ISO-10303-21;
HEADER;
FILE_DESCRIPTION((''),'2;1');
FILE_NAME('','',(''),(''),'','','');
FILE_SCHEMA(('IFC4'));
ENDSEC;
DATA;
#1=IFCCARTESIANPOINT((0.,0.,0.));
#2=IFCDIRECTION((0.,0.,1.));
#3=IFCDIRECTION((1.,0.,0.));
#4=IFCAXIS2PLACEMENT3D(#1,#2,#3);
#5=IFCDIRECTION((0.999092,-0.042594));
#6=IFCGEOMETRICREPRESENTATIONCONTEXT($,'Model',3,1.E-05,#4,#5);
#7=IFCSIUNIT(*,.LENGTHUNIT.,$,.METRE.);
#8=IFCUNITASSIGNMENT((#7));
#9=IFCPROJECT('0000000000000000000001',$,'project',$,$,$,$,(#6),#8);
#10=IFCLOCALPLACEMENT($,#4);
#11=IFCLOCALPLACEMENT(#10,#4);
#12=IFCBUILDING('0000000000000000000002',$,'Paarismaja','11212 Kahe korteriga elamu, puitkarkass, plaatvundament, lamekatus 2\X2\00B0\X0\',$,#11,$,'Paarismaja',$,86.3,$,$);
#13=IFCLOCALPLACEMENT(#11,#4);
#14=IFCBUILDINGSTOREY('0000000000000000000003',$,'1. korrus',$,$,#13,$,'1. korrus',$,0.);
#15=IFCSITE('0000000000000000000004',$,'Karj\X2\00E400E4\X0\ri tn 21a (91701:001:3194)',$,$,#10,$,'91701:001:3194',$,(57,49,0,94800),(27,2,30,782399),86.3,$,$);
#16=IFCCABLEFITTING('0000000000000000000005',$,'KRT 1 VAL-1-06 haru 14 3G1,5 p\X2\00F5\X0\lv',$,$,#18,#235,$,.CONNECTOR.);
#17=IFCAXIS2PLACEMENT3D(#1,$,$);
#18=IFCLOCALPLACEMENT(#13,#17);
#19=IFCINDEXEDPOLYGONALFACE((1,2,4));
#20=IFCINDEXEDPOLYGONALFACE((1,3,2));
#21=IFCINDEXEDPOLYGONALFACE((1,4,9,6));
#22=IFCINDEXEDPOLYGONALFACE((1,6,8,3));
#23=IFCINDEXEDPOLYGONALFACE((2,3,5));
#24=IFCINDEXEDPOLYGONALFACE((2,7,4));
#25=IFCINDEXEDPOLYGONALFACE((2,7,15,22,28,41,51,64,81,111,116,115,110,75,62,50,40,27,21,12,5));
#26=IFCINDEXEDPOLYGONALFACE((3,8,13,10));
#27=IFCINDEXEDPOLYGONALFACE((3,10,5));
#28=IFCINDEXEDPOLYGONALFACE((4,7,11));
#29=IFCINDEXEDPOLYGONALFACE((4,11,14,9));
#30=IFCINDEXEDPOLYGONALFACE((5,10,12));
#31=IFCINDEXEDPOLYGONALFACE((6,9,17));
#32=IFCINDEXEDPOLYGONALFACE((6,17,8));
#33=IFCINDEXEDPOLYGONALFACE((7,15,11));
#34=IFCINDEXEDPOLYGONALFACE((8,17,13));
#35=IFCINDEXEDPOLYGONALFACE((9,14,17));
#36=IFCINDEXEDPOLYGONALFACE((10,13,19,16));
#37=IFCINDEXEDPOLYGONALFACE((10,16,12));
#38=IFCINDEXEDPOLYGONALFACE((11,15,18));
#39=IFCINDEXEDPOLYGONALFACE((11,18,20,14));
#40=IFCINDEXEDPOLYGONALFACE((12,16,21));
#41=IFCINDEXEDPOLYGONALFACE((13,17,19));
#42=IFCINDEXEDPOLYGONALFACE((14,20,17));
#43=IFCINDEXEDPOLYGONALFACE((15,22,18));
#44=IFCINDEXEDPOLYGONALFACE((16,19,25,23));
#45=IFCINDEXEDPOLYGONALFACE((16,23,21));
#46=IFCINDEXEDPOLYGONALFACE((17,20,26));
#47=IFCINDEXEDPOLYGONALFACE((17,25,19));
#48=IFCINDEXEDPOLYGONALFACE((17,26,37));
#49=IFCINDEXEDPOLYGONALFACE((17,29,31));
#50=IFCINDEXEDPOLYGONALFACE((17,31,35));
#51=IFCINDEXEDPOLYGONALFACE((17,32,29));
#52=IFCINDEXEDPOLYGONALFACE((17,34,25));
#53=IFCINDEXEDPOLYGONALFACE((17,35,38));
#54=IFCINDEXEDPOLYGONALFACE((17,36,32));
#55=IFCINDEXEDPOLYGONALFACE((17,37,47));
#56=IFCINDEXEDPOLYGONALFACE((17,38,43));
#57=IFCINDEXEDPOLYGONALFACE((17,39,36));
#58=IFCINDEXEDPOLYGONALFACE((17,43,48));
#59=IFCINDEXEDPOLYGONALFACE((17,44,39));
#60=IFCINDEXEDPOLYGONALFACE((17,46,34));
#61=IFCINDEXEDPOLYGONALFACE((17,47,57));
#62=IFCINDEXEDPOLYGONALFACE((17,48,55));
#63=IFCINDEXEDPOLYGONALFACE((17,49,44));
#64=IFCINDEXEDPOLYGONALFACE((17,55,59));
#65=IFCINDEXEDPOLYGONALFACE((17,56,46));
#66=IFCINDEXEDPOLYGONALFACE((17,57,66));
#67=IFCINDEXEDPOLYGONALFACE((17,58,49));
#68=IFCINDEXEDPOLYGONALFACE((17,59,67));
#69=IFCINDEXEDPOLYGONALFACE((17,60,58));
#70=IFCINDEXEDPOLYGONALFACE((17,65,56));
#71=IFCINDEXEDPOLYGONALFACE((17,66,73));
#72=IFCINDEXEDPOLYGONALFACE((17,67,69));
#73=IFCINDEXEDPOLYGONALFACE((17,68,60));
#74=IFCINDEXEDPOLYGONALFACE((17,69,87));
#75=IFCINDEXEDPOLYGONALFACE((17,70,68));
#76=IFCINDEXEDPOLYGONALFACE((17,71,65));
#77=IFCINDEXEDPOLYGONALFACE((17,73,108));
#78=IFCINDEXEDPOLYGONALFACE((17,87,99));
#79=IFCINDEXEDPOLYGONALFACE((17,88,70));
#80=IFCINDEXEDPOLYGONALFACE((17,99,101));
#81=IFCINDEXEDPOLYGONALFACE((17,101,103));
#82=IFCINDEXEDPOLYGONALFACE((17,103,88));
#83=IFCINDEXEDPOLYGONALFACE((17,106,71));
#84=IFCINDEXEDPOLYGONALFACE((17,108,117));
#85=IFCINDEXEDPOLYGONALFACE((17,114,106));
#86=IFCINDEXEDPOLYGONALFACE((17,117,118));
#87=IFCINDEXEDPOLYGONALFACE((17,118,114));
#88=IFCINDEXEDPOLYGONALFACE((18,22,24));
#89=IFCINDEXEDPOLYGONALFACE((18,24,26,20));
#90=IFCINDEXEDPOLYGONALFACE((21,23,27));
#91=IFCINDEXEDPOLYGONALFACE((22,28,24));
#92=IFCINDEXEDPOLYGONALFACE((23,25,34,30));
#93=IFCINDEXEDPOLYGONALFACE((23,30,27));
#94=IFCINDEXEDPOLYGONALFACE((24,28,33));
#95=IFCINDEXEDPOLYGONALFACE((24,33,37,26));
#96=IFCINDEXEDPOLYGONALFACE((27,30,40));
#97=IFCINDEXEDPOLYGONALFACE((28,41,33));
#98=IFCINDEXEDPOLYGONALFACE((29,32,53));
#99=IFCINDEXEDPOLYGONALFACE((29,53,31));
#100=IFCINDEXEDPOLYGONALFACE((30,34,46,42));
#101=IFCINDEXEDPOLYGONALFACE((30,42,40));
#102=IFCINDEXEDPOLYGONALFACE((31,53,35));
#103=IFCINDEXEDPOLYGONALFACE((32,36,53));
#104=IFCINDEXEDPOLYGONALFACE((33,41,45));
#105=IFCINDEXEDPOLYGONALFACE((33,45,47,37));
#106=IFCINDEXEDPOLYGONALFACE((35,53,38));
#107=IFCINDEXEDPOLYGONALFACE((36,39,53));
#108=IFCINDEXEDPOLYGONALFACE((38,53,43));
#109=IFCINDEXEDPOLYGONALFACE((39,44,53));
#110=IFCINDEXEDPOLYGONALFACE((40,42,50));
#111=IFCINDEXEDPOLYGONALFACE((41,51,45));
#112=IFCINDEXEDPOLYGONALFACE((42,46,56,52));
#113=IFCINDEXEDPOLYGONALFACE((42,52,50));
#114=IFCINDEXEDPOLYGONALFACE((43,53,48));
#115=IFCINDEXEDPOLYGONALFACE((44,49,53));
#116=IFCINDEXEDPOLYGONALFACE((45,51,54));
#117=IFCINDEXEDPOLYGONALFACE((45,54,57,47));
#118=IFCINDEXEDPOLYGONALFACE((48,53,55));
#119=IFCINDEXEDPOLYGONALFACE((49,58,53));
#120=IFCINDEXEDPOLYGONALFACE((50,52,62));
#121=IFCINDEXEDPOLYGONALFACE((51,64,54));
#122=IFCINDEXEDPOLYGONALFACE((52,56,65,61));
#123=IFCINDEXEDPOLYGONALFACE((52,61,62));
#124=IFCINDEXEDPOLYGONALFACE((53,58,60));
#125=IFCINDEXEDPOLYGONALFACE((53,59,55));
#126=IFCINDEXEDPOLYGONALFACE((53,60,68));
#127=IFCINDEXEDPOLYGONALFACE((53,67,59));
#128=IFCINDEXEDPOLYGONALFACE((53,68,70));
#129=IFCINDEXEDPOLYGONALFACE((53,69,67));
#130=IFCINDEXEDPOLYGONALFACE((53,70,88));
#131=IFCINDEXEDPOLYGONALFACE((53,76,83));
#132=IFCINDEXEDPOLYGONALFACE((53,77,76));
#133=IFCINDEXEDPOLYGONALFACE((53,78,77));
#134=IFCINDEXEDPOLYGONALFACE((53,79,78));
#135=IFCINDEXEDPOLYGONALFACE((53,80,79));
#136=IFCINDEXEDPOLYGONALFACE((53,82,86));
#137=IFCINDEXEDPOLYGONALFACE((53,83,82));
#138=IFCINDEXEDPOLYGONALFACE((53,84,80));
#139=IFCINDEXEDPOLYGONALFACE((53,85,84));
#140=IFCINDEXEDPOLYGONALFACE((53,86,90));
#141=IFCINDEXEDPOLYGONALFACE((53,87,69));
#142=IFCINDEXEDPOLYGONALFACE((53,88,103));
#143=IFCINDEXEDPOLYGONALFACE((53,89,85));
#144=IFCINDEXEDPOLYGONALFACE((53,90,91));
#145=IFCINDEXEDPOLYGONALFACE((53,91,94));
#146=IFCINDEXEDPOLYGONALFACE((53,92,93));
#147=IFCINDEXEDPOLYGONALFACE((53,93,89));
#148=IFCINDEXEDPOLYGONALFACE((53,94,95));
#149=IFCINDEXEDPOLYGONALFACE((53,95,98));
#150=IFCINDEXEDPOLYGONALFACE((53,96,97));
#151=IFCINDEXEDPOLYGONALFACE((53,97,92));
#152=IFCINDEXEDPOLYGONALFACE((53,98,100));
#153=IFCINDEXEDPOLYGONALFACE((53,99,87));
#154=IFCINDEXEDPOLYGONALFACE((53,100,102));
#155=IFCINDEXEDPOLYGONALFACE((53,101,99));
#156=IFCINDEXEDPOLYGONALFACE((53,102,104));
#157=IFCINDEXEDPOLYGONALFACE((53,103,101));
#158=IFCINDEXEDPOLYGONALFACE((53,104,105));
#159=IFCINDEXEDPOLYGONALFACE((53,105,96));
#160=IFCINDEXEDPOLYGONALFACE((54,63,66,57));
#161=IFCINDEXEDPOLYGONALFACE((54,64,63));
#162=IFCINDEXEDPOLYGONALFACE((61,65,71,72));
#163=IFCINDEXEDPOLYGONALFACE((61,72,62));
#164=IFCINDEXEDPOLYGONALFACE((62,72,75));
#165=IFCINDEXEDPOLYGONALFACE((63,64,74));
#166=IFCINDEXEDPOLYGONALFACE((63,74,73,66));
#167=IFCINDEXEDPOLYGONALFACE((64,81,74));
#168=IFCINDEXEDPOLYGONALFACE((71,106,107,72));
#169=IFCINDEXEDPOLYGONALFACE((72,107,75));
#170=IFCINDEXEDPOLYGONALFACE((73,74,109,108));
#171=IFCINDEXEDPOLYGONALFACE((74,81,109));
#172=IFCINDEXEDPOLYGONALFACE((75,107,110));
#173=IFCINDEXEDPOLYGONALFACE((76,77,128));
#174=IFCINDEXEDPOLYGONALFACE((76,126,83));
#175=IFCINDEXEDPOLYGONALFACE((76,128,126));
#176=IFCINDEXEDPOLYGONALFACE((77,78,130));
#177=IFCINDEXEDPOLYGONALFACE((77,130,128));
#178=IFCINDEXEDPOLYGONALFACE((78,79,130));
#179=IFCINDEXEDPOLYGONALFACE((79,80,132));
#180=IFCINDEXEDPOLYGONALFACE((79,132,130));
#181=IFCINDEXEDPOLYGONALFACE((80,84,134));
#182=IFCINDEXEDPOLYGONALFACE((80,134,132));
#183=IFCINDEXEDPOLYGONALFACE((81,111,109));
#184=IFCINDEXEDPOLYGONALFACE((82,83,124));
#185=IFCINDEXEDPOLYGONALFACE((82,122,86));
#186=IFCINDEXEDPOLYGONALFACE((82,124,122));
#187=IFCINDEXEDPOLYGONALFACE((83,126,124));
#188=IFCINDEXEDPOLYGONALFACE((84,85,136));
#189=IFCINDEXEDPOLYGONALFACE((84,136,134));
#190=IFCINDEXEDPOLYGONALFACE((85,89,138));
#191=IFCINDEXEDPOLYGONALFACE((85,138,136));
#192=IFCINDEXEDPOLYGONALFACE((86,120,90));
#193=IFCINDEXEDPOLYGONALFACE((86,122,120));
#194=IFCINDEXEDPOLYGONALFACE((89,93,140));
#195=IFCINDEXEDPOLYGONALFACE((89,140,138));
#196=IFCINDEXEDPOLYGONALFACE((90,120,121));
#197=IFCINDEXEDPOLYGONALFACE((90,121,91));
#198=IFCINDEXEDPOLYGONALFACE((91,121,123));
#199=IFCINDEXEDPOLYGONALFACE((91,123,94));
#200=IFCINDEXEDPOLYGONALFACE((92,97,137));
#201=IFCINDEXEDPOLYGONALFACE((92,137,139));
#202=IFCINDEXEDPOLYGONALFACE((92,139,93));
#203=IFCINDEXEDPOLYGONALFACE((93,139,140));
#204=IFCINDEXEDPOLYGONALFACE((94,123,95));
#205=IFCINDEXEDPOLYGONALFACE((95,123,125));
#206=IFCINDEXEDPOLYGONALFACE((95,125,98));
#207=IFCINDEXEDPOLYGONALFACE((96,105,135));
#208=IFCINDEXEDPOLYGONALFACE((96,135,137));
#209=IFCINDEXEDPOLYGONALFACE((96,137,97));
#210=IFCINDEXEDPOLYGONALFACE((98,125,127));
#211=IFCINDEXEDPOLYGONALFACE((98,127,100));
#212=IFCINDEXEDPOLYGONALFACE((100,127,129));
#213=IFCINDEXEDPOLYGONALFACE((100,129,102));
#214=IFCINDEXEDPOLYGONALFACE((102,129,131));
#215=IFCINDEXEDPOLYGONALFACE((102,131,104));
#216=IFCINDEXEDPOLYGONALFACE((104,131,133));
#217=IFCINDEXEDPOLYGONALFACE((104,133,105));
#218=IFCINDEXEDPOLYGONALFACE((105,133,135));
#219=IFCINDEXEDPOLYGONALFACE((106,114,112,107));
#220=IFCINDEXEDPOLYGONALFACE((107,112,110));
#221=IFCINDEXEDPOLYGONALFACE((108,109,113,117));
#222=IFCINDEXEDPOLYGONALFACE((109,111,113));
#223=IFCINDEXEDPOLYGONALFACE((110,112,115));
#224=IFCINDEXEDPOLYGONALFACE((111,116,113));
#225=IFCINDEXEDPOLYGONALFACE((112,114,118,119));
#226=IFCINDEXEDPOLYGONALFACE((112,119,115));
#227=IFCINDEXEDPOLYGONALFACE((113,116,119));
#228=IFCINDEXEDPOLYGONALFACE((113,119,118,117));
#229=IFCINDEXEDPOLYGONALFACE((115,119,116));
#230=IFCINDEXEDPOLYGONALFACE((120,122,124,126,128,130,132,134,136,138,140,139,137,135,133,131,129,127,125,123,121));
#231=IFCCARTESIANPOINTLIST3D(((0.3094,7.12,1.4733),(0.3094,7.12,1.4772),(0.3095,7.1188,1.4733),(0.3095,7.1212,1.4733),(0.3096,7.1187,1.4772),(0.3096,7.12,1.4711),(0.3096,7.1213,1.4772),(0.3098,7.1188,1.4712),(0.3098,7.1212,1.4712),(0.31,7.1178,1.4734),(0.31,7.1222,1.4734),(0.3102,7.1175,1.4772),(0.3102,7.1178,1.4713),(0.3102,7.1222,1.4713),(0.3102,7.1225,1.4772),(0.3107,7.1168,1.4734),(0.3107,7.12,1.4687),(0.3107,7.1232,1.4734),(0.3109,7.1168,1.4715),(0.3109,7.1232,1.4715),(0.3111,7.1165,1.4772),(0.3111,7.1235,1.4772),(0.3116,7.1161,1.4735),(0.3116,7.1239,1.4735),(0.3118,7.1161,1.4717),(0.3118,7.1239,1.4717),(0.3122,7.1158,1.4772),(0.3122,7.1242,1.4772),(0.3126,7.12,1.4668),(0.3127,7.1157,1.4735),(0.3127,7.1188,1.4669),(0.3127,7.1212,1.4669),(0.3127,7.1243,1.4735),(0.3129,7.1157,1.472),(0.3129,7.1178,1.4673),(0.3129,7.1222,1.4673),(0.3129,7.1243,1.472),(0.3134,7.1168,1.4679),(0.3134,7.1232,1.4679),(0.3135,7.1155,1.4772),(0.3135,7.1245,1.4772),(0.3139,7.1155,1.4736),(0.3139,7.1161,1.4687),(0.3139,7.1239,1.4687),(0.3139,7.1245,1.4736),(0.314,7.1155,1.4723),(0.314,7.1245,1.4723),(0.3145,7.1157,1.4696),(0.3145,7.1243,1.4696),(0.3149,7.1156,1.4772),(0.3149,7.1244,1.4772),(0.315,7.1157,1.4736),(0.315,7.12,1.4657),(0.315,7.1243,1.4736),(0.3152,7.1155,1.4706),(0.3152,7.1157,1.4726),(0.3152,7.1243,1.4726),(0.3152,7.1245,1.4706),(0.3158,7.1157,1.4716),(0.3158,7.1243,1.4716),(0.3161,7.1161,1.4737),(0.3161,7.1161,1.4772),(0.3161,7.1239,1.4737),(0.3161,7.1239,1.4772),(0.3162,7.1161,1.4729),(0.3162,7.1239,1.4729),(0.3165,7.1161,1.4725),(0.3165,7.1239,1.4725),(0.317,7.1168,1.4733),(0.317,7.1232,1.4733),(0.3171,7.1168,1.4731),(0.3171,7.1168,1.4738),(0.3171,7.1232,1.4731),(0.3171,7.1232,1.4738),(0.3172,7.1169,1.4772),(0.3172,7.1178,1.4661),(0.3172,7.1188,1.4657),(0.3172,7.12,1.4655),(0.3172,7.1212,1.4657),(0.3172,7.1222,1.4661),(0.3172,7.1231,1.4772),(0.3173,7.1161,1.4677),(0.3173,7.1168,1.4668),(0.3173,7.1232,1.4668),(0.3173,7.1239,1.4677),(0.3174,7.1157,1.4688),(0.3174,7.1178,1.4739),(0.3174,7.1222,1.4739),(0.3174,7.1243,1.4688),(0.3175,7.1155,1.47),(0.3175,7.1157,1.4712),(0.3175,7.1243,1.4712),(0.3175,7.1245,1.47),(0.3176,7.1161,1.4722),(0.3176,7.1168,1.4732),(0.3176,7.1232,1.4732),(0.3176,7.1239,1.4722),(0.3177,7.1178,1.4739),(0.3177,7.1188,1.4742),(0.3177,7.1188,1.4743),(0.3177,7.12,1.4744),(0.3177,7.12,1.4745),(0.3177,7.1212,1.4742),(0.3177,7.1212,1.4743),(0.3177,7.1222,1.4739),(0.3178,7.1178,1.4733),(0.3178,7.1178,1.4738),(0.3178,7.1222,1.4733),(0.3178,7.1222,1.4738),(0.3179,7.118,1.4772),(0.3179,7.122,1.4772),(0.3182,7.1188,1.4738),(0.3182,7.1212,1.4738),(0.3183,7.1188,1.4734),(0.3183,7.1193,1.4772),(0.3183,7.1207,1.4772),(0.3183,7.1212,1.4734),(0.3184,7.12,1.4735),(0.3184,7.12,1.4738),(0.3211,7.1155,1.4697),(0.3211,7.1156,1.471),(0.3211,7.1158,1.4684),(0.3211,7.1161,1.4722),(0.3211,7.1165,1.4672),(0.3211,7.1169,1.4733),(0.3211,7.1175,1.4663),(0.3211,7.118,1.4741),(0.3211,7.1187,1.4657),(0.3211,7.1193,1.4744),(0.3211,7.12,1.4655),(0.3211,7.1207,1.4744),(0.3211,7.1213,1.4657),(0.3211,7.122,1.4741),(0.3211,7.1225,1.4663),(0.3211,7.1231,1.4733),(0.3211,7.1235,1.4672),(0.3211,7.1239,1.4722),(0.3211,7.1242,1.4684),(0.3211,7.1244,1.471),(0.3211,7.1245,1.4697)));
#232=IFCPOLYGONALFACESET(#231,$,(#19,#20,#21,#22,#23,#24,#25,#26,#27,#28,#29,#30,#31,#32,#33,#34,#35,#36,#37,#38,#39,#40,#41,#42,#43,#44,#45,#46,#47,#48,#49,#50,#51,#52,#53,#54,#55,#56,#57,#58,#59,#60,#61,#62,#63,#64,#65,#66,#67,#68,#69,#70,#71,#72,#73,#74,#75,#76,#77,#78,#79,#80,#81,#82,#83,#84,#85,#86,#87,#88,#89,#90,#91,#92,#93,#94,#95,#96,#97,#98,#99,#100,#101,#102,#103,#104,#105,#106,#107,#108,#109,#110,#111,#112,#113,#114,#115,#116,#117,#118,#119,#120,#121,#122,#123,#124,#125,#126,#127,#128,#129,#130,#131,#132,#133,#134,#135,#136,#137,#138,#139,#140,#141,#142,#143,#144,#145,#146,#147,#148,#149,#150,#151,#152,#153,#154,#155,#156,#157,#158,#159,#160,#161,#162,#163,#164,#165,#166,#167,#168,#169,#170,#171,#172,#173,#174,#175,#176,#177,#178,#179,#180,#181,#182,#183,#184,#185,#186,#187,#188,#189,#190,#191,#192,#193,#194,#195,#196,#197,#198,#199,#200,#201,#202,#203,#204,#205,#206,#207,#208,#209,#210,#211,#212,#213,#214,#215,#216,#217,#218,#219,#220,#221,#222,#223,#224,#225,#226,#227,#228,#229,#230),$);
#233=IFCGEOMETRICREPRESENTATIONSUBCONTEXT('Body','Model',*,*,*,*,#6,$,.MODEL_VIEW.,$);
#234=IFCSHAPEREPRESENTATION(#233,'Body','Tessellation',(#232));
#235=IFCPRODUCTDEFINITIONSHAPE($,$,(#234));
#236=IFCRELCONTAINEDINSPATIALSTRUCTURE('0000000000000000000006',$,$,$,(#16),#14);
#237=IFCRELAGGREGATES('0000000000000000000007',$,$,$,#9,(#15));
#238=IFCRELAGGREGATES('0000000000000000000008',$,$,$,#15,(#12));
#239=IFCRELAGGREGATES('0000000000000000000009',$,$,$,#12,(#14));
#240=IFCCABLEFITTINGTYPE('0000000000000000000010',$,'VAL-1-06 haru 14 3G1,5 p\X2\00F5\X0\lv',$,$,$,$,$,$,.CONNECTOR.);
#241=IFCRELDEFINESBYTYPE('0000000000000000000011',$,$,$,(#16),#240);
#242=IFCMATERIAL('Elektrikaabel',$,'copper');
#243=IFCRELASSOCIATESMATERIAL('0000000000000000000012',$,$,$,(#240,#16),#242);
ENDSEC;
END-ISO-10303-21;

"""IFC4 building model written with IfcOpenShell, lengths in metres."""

from ifc_helpers import new_model, entity, si_unit, direction, frame, origin_with_axes, place, context, subcontext, project, spatial, material, type_object, element, save


model = new_model("IFC4")

# Units and contexts
model_context = context("Model", 3, precision=1e-05, world=origin_with_axes(), true_north=direction((0.999092, -0.042594)))
body_context = subcontext(model_context, "Body", "Model", "MODEL_VIEW")
ifc_project = project(units=[si_unit("LENGTHUNIT", "METRE")], contexts=[model_context])

# Site, building, storey
site_placement = place(None, origin_with_axes())
site = spatial("IfcSite", under=ifc_project, at=site_placement, Name="Karjääri tn 21a (91701:001:3194)", LongName="91701:001:3194", RefLatitude=(57, 49, 0, 94800), RefLongitude=(27, 2, 30, 782399), RefElevation=86.3)
building_placement = place(site_placement, origin_with_axes())
building = spatial("IfcBuilding", under=site, at=building_placement, Name="Paarismaja", Description="11212 Kahe korteriga elamu, puitkarkass, plaatvundament, lamekatus 2°", LongName="Paarismaja", ElevationOfRefHeight=86.3)
storey_placement = place(building_placement, origin_with_axes())
storey = spatial("IfcBuildingStorey", under=building, at=storey_placement, Name="1. korrus", LongName="1. korrus", Elevation=0.0)

# Cable fitting
ifc_material_1 = material(Name="Elektrikaabel", Category="copper")
cable_fitting_type_1 = type_object("IfcCableFittingType", Name="VAL-1-06 haru 14 3G1,5 põlv", PredefinedType="CONNECTOR", material=ifc_material_1)
cable_fitting_1_placement = place(storey_placement, frame((0.3139, 7.12, 1.47), z_axis=(0.0, 0.0, 1.0), x_axis=(1.0, 0.0, 0.0)))
element("IfcCableFitting", 1, at=cable_fitting_1_placement, inside=storey, type_object=cable_fitting_type_1, material=ifc_material_1, Name="KRT 1 VAL-1-06 haru 14 3G1,5 põlv", PredefinedType="CONNECTOR", context=body_context, shape_type="AdvancedSweptSolid", body=[
    entity("IfcSweptDiskSolid", entity("IfcIndexedPolyCurve", entity("IfcCartesianPointList3D", [[0.0, 0.0, 0.0072], [0.0, 0.0, 0.0036], [0.0001, 0.0, 0.0023], [0.0006, 0.0, 0.0013], [0.0013, 0.0, 0.0006], [0.0023, 0.0, 0.0001], [0.0036, 0.0, 0.0], [0.0072, 0.0, 0.0]]), None, False), 0.0045),
])

save(model, "model.ifc")
